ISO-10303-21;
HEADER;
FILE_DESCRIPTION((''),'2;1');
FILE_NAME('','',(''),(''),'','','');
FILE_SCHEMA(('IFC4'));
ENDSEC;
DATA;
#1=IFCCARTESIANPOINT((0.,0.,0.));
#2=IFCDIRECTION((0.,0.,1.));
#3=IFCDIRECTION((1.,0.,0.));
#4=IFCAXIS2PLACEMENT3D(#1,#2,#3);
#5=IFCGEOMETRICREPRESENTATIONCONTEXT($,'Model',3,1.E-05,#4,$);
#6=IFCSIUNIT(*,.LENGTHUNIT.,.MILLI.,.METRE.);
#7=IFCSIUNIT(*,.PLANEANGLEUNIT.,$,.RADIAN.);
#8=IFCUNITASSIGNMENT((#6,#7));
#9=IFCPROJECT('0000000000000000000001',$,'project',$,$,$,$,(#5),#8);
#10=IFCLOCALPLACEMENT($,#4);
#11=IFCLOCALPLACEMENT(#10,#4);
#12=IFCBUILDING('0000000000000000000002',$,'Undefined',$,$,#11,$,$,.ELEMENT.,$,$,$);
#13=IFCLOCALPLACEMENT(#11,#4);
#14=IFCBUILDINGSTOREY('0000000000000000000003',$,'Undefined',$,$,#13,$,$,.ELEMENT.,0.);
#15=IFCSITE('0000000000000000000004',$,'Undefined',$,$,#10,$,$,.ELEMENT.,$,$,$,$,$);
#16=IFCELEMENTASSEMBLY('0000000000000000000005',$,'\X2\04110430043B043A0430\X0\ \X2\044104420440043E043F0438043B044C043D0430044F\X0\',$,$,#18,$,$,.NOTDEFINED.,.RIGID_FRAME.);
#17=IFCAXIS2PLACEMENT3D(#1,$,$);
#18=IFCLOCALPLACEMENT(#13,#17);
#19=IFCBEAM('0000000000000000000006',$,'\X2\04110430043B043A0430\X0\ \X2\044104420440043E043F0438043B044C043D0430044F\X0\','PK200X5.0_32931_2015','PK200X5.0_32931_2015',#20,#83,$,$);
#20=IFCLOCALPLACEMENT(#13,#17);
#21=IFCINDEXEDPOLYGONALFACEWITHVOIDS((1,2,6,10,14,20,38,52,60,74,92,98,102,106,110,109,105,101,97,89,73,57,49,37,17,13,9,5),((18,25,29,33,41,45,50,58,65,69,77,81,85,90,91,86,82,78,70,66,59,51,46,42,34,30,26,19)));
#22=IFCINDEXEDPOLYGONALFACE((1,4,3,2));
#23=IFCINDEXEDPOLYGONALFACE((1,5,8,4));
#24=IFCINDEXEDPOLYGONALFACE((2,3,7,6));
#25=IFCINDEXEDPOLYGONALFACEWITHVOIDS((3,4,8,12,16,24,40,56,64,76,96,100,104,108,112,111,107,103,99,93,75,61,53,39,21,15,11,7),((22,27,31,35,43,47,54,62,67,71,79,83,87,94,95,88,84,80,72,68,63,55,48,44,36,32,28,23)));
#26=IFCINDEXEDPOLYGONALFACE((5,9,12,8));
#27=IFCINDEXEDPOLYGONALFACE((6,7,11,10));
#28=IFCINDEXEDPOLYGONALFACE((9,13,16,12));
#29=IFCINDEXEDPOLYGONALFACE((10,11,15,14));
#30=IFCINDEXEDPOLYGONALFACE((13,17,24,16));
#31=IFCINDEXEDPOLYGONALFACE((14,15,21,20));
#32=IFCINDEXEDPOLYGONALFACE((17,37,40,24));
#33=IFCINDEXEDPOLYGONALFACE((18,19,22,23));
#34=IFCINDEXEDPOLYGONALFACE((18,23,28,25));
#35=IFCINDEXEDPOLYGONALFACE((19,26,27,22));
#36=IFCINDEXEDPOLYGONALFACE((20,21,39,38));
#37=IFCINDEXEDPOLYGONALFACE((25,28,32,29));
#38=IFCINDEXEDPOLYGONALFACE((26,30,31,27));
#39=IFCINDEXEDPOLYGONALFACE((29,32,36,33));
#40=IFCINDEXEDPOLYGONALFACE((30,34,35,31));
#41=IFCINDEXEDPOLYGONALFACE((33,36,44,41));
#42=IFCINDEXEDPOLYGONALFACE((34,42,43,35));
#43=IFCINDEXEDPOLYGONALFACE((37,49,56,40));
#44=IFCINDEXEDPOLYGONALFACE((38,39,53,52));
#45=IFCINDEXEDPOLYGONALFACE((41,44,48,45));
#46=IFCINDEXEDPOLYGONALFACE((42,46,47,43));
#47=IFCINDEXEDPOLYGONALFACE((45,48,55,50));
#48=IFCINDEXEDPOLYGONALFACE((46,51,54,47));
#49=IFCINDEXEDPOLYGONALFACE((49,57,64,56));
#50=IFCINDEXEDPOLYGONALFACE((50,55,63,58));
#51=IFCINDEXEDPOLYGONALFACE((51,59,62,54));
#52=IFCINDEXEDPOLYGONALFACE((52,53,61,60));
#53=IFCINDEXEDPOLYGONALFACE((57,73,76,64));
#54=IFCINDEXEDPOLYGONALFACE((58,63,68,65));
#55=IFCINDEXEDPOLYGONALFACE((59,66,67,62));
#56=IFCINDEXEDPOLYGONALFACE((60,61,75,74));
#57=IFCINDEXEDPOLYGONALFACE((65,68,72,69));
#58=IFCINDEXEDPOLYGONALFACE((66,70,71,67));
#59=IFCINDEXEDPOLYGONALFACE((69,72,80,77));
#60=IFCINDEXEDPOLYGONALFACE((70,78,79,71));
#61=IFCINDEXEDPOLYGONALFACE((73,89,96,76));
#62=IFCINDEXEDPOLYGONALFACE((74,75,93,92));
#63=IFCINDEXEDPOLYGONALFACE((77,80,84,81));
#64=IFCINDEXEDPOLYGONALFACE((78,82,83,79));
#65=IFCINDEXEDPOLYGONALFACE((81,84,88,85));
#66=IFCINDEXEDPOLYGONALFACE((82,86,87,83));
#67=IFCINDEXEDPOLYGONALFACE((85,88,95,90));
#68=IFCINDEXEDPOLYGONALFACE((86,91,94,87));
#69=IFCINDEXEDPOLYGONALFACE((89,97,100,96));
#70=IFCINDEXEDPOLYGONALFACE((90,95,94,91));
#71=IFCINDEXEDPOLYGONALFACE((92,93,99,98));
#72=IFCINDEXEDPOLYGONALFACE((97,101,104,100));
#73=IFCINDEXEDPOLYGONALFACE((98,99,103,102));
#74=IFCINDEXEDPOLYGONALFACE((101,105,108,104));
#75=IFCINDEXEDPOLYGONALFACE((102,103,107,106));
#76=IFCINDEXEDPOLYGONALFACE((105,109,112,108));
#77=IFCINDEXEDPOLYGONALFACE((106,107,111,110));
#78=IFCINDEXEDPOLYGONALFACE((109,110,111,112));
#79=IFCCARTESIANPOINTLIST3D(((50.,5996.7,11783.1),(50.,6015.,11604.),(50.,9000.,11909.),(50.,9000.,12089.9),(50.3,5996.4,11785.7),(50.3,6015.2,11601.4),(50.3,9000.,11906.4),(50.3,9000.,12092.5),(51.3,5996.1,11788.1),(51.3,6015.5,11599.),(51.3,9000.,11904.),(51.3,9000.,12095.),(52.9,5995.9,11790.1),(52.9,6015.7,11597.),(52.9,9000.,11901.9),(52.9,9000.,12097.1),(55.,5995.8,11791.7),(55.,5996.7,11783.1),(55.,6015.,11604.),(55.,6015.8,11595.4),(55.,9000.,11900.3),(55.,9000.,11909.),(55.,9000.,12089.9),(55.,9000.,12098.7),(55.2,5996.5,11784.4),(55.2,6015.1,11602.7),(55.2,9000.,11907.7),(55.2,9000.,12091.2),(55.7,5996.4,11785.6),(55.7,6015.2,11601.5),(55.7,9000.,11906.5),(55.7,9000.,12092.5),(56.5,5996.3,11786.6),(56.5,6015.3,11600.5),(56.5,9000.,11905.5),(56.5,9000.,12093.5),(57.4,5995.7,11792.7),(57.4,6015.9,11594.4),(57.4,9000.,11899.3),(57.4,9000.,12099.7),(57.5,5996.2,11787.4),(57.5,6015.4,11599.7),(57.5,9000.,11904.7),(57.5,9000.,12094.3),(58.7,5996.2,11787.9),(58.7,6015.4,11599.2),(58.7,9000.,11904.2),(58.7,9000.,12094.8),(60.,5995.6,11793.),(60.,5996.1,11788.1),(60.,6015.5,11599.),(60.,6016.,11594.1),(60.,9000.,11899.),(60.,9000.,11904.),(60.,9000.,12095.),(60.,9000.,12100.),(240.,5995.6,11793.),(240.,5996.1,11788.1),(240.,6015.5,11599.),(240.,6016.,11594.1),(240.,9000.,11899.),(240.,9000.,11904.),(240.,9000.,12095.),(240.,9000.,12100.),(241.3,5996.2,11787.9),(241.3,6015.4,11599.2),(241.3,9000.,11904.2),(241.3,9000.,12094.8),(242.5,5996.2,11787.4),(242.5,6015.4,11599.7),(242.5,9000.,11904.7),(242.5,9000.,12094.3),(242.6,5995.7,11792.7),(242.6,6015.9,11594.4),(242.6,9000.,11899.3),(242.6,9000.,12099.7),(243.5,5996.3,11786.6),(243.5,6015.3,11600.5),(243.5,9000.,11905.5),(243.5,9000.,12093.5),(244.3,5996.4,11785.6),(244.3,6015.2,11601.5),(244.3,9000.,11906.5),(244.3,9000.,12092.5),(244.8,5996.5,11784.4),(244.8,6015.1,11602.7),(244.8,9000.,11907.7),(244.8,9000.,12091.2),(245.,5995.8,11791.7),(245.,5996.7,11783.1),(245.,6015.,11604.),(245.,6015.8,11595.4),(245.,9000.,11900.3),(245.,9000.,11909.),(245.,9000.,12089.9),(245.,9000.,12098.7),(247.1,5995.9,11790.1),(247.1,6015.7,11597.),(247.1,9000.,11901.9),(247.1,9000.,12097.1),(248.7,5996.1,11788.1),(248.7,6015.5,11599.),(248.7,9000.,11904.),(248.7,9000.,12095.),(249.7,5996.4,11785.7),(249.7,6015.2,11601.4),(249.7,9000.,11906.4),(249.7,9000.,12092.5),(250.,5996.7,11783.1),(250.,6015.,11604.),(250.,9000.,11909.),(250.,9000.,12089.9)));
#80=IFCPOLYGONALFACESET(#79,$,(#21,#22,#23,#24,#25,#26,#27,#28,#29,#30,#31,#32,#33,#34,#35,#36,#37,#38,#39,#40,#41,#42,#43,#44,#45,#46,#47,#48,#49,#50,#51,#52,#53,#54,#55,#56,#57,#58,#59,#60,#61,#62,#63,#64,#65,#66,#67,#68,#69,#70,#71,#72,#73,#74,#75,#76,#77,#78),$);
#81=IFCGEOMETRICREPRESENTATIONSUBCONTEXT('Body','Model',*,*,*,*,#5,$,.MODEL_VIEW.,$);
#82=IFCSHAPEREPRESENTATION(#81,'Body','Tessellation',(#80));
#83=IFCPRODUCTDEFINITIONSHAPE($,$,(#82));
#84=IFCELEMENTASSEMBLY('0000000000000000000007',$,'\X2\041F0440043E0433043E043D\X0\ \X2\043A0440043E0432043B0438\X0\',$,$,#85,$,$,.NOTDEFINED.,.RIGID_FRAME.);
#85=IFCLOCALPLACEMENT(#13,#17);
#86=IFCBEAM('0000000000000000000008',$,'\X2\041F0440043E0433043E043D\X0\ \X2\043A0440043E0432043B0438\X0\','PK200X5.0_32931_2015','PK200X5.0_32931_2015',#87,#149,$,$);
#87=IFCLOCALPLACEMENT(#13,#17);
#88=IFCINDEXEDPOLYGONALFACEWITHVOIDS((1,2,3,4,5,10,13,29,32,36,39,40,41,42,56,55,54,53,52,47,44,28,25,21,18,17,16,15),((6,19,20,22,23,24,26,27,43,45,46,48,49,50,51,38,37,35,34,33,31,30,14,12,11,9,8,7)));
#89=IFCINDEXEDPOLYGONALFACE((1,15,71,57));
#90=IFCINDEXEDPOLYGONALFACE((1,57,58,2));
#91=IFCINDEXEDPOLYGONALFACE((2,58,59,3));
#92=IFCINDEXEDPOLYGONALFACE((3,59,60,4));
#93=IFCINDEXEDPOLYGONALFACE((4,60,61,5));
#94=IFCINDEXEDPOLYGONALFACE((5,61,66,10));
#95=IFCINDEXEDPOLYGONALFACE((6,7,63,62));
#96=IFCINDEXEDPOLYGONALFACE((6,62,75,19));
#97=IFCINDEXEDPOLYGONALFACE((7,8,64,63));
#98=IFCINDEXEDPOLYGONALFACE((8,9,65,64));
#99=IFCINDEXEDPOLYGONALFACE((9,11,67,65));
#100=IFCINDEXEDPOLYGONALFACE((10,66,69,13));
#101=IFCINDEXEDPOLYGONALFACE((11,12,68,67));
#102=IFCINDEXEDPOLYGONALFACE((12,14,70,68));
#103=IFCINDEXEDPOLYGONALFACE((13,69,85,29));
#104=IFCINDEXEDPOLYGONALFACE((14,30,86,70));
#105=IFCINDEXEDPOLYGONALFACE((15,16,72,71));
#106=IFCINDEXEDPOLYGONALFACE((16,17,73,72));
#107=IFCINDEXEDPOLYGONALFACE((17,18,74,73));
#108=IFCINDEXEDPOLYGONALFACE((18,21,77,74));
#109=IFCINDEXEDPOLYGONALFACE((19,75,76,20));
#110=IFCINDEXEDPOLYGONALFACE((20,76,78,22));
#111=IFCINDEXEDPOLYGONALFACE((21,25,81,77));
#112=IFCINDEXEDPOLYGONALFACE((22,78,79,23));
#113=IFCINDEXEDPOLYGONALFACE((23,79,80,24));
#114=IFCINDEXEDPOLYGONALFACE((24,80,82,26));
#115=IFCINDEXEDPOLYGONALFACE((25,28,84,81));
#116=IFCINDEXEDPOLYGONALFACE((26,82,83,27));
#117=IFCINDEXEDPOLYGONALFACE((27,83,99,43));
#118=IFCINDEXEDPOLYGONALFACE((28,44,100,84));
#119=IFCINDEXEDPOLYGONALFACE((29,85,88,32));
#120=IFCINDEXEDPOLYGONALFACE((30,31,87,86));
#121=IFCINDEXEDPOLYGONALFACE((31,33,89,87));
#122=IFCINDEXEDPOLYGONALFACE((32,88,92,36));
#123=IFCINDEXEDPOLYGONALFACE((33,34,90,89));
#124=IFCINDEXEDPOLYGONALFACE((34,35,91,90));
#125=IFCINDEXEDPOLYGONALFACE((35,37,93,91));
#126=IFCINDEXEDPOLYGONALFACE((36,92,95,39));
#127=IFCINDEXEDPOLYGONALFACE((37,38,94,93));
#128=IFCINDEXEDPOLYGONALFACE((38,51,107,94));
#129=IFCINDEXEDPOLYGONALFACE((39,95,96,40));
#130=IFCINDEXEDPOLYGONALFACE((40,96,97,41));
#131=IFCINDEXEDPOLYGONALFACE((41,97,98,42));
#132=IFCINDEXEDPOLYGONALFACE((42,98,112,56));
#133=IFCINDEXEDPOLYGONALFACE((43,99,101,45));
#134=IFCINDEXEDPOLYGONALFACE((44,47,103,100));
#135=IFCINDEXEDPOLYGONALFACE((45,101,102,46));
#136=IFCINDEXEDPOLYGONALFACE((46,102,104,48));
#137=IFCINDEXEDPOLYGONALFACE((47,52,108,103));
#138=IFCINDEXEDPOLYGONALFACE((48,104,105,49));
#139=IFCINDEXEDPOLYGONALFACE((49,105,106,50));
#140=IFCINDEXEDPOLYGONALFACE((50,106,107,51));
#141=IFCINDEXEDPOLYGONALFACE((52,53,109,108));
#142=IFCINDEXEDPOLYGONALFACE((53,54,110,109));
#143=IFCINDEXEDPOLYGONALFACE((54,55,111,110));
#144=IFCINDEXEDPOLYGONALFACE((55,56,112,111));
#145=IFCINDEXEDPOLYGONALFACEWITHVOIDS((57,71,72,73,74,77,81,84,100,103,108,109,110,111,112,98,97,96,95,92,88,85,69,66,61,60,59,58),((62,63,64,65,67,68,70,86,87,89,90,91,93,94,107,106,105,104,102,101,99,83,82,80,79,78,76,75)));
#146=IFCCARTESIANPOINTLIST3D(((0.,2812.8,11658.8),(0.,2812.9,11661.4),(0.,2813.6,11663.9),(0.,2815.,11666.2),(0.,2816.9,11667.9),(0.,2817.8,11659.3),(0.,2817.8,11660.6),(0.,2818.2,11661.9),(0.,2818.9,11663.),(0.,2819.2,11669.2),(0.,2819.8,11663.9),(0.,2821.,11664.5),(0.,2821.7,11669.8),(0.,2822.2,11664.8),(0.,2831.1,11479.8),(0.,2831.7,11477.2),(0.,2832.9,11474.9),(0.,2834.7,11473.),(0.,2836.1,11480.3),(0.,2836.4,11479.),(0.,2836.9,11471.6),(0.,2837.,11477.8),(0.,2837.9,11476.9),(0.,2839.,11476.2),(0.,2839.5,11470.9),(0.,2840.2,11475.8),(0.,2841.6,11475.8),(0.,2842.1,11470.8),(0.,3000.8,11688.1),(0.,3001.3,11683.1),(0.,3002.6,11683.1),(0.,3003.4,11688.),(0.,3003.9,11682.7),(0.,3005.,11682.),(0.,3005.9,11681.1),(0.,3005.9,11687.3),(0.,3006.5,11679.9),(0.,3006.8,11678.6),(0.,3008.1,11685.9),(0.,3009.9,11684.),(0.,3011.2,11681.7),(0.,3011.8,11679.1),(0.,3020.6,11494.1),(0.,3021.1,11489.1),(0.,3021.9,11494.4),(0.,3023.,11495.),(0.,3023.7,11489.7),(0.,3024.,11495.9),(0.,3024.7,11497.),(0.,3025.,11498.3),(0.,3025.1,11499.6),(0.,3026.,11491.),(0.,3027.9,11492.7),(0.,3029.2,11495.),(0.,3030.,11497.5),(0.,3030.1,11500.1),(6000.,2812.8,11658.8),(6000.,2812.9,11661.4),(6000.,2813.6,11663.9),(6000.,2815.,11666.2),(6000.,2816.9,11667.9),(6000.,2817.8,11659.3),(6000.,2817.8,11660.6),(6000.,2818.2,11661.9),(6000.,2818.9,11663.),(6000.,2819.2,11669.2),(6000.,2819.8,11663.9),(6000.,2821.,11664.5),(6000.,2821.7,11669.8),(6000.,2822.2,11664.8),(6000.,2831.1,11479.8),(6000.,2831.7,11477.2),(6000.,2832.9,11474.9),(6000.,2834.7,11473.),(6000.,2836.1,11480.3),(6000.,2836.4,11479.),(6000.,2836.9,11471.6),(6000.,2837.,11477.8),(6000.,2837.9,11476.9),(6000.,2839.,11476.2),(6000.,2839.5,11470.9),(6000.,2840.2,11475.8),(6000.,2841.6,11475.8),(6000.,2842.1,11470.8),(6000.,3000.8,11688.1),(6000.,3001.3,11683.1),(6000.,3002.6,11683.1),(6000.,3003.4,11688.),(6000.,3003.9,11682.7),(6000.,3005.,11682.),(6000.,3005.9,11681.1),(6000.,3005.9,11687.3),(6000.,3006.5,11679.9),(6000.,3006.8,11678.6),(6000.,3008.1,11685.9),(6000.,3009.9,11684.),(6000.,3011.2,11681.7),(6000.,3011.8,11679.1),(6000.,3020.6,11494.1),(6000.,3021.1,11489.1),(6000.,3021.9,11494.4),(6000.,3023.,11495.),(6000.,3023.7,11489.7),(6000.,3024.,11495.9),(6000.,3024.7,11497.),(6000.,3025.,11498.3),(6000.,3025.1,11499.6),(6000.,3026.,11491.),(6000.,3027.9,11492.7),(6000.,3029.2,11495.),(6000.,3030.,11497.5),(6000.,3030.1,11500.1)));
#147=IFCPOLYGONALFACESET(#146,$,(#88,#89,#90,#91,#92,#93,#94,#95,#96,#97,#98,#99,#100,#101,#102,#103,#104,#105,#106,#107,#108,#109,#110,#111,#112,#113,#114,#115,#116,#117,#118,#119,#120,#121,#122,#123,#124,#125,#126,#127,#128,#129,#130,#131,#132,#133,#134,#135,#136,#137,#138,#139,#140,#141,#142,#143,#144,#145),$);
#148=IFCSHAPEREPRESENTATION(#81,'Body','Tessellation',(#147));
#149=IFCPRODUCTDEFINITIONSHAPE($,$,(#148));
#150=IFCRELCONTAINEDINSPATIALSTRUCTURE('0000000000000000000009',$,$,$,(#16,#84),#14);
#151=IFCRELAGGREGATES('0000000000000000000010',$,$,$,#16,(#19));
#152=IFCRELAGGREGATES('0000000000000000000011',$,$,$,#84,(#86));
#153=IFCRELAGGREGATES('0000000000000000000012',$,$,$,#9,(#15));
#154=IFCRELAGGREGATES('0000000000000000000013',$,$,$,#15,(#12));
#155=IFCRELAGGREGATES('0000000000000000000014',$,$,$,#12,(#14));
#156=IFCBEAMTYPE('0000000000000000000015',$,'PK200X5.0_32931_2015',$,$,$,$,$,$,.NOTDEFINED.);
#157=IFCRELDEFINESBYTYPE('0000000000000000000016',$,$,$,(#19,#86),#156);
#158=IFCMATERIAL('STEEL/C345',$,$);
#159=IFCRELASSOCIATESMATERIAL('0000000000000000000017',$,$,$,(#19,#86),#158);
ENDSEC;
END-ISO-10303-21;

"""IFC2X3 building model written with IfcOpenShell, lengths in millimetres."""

from ifc_helpers import new_model, si_unit, frame, origin_with_axes, origin_2d_with_axis, place, context, subcontext, project, spatial, hollow_rectangle, extrude, clip, halfspace, material, type_object, element, aggregate, save


model = new_model("IFC2X3")

# Units and contexts
model_context = context("Model", 3, precision=1e-05, world=origin_with_axes())
body_context = subcontext(model_context, "Body", "Model", "MODEL_VIEW")
ifc_project = project(units=[si_unit("LENGTHUNIT", "METRE", prefix="MILLI"), si_unit("PLANEANGLEUNIT", "RADIAN")], contexts=[model_context])

# Site, building, storey
site_placement = place(None, origin_with_axes())
site = spatial("IfcSite", under=ifc_project, at=site_placement, Name="Undefined", CompositionType="ELEMENT")
building_placement = place(site_placement, origin_with_axes())
building = spatial("IfcBuilding", under=site, at=building_placement, Name="Undefined", CompositionType="ELEMENT")
storey_placement = place(building_placement, origin_with_axes())
storey = spatial("IfcBuildingStorey", under=building, at=storey_placement, Name="Undefined", CompositionType="ELEMENT", Elevation=0.0)

# Element assemblies, beams
ifc_material_1 = material(Name="STEEL/C345")
beam_type_1 = type_object("IfcBeamType", Name="PK200X5.0_32931_2015", PredefinedType="NOTDEFINED")
assembly_1_placement = place(storey_placement, origin_with_axes())
assembly_1 = element("IfcElementAssembly", 1, at=assembly_1_placement, inside=storey, Name="Балка стропильная", AssemblyPlace="NOTDEFINED", PredefinedType="RIGID_FRAME")
beam_1_placement = place(assembly_1_placement, frame((150.0, 6005.8, 11693.6), z_axis=(0.0, -0.101645, 0.994821), x_axis=(0.0, 0.994821, 0.101645)))
beam_1 = element("IfcBeam", 2, at=beam_1_placement, type_object=beam_type_1, material=ifc_material_1, Name="Балка стропильная", Description="PK200X5.0_32931_2015", ObjectType="PK200X5.0_32931_2015", context=body_context, shape_type="Clipping", body=[
    clip(extrude(hollow_rectangle(XDim=200.0, YDim=200.0, WallThickness=5.0, InnerFilletRadius=5.0, OuterFilletRadius=10.0, at=origin_2d_with_axis()), frame((3040.5, 0.0, 0.0), z_axis=(-1.0, 0.0, 0.0), x_axis=(0.0, -1.0, 0.0)), (0.0, 0.0, 1.0), 3040.5), halfspace(frame((3020.0, 0.0, 100.0), z_axis=(0.994821, 0.0, -0.101645), x_axis=(0.0, -1.0, 0.0)), False)),
])
aggregate(assembly_1, [beam_1])
assembly_2_placement = place(storey_placement, origin_with_axes())
assembly_2 = element("IfcElementAssembly", 3, at=assembly_2_placement, inside=storey, Name="Прогон кровли", AssemblyPlace="NOTDEFINED", PredefinedType="RIGID_FRAME")
beam_2_placement = place(assembly_2_placement, frame((6000.0, 2921.4, 11579.4), z_axis=(0.0, -0.101645, 0.994821), x_axis=(-1.0, 0.0, 0.0)))
beam_2 = element("IfcBeam", 4, at=beam_2_placement, type_object=beam_type_1, material=ifc_material_1, Name="Прогон кровли", Description="PK200X5.0_32931_2015", ObjectType="PK200X5.0_32931_2015", context=body_context, shape_type="SweptSolid", body=[
    extrude(hollow_rectangle(XDim=200.0, YDim=200.0, WallThickness=5.0, InnerFilletRadius=5.0, OuterFilletRadius=10.0, at=origin_2d_with_axis()), frame((6000.0, 0.0, 0.0), z_axis=(-1.0, 0.0, 0.0), x_axis=(0.0, -1.0, 0.0)), (0.0, 0.0, 1.0), 6000.0),
])
aggregate(assembly_2, [beam_2])

save(model, "model.ifc")
